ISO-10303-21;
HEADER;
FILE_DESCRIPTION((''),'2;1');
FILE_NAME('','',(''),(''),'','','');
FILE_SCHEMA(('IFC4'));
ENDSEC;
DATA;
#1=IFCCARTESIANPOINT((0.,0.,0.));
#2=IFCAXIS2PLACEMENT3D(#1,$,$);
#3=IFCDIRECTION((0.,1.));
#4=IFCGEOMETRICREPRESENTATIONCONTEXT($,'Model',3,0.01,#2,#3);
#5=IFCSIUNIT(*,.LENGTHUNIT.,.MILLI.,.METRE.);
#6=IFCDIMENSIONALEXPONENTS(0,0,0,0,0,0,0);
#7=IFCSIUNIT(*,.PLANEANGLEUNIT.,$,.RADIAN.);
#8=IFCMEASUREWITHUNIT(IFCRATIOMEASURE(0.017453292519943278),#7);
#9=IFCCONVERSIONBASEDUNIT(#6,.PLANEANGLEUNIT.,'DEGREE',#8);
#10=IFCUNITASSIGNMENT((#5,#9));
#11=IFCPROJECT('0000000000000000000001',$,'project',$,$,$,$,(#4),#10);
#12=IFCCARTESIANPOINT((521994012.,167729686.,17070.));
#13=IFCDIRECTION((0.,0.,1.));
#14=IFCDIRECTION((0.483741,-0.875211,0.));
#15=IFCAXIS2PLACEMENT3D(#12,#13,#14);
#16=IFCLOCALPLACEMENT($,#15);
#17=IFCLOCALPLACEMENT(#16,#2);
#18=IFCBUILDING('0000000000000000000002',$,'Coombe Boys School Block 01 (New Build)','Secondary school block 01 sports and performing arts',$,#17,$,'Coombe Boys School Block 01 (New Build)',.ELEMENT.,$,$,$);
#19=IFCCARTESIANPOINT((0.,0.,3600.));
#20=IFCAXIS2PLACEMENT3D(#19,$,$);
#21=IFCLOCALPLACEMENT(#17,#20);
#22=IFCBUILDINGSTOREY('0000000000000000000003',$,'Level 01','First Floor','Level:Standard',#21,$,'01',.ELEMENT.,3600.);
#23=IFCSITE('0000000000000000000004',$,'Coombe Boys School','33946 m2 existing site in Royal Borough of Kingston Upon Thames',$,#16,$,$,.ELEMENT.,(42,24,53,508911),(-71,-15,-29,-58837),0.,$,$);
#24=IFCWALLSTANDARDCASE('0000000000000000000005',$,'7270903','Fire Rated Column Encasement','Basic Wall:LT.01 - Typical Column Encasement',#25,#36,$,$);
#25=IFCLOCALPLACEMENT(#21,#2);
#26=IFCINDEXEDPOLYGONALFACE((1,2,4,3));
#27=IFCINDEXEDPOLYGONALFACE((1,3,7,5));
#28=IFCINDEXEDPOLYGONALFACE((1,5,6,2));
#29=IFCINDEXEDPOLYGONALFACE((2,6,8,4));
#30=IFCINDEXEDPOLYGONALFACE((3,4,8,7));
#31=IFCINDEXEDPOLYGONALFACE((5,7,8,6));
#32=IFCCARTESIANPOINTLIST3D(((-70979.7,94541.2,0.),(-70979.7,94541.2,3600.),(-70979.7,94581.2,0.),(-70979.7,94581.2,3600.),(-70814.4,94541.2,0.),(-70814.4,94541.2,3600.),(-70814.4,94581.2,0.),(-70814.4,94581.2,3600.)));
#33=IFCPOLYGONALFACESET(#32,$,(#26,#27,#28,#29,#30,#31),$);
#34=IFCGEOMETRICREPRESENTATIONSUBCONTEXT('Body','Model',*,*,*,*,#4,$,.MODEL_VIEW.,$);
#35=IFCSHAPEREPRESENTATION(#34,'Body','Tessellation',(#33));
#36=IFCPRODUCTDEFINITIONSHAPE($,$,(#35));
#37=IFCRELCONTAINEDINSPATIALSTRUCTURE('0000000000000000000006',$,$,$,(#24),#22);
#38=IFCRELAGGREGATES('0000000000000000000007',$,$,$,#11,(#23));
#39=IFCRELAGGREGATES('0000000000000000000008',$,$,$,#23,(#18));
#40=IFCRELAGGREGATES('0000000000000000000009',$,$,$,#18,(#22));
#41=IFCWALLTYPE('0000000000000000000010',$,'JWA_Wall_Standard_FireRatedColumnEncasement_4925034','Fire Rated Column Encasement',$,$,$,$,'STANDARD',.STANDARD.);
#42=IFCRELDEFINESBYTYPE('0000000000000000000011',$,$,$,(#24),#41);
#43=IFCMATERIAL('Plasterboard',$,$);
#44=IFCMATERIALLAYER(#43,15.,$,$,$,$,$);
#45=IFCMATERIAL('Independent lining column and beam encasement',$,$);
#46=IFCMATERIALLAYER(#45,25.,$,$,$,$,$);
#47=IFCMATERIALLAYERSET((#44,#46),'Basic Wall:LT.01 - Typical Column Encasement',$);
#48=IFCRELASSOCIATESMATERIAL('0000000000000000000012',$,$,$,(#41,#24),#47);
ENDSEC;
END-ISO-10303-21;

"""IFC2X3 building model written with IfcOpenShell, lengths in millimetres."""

from ifc_helpers import new_model, entity, si_unit, converted_unit, direction, frame, frame_2d, origin, place, context, subcontext, project, spatial, rectangle, extrude, material, layer, layer_set, layer_usage, type_object, element, save


model = new_model("IFC2X3")

# Units and contexts
model_context = context("Model", 3, precision=0.01, world=origin(), true_north=direction((0.0, 1.0)))
body_context = subcontext(model_context, "Body", "Model", "MODEL_VIEW")
ifc_project = project(units=[si_unit("LENGTHUNIT", "METRE", prefix="MILLI"), converted_unit("PLANEANGLEUNIT", "DEGREE", entity("IfcRatioMeasure", 0.017453292519943278), si_unit("PLANEANGLEUNIT", "RADIAN"), dimensions=[0, 0, 0, 0, 0, 0, 0])], contexts=[model_context])

# Site, building, storey
site_placement = place(None, frame((521994012.0, 167729686.0, 17070.0), z_axis=(0.0, 0.0, 1.0), x_axis=(0.483741, -0.875211, 0.0)))
site = spatial("IfcSite", under=ifc_project, at=site_placement, Name="Coombe Boys School", Description="33946 m2 existing site in Royal Borough of Kingston Upon Thames", CompositionType="ELEMENT", RefLatitude=(42, 24, 53, 508911), RefLongitude=(-71, -15, -29, -58837), RefElevation=0.0)
building_placement = place(site_placement, origin())
building = spatial("IfcBuilding", under=site, at=building_placement, Name="Coombe Boys School Block 01 (New Build)", Description="Secondary school block 01 sports and performing arts", LongName="Coombe Boys School Block 01 (New Build)", CompositionType="ELEMENT")
storey_placement = place(building_placement, frame((0.0, 0.0, 3600.0)))
storey = spatial("IfcBuildingStorey", under=building, at=storey_placement, Name="Level 01", Description="First Floor", ObjectType="Level:Standard", LongName="01", CompositionType="ELEMENT", Elevation=3600.0)

# Wall
ifc_material_1 = material(Name="Plasterboard")
ifc_layer_1 = layer(ifc_material_1, 15.0)
ifc_material_2 = material(Name="Independent lining column and beam encasement")
ifc_layer_2 = layer(ifc_material_2, 25.0)
ifc_layer_set = layer_set([ifc_layer_1, ifc_layer_2], Name="Basic Wall:LT.01 - Typical Column Encasement")
ifc_layer_usage = layer_usage(ifc_layer_set, "AXIS2", "POSITIVE", -20.0)
wall_type = type_object("IfcWallType", Name="JWA_Wall_Standard_FireRatedColumnEncasement_4925034", Description="Fire Rated Column Encasement", ElementType="STANDARD", PredefinedType="STANDARD", material=ifc_layer_set)
wall_placement = place(storey_placement, frame((-70814.4, 94561.2, 0.0), z_axis=(0.0, 0.0, 1.0), x_axis=(-1.0, 0.0, 0.0)))
element("IfcWallStandardCase", 1, at=wall_placement, inside=storey, type_object=wall_type, material=ifc_layer_usage, Name="7270903", Description="Fire Rated Column Encasement", ObjectType="Basic Wall:LT.01 - Typical Column Encasement", context=body_context, shape_type="SweptSolid", body=[
    extrude(rectangle(XDim=165.3, YDim=40.0, at=frame_2d((82.6, 0.0), x_axis=(-1.0, 0.0))), origin(), (0.0, 0.0, 1.0), 3600.0),
])

save(model, "model.ifc")
